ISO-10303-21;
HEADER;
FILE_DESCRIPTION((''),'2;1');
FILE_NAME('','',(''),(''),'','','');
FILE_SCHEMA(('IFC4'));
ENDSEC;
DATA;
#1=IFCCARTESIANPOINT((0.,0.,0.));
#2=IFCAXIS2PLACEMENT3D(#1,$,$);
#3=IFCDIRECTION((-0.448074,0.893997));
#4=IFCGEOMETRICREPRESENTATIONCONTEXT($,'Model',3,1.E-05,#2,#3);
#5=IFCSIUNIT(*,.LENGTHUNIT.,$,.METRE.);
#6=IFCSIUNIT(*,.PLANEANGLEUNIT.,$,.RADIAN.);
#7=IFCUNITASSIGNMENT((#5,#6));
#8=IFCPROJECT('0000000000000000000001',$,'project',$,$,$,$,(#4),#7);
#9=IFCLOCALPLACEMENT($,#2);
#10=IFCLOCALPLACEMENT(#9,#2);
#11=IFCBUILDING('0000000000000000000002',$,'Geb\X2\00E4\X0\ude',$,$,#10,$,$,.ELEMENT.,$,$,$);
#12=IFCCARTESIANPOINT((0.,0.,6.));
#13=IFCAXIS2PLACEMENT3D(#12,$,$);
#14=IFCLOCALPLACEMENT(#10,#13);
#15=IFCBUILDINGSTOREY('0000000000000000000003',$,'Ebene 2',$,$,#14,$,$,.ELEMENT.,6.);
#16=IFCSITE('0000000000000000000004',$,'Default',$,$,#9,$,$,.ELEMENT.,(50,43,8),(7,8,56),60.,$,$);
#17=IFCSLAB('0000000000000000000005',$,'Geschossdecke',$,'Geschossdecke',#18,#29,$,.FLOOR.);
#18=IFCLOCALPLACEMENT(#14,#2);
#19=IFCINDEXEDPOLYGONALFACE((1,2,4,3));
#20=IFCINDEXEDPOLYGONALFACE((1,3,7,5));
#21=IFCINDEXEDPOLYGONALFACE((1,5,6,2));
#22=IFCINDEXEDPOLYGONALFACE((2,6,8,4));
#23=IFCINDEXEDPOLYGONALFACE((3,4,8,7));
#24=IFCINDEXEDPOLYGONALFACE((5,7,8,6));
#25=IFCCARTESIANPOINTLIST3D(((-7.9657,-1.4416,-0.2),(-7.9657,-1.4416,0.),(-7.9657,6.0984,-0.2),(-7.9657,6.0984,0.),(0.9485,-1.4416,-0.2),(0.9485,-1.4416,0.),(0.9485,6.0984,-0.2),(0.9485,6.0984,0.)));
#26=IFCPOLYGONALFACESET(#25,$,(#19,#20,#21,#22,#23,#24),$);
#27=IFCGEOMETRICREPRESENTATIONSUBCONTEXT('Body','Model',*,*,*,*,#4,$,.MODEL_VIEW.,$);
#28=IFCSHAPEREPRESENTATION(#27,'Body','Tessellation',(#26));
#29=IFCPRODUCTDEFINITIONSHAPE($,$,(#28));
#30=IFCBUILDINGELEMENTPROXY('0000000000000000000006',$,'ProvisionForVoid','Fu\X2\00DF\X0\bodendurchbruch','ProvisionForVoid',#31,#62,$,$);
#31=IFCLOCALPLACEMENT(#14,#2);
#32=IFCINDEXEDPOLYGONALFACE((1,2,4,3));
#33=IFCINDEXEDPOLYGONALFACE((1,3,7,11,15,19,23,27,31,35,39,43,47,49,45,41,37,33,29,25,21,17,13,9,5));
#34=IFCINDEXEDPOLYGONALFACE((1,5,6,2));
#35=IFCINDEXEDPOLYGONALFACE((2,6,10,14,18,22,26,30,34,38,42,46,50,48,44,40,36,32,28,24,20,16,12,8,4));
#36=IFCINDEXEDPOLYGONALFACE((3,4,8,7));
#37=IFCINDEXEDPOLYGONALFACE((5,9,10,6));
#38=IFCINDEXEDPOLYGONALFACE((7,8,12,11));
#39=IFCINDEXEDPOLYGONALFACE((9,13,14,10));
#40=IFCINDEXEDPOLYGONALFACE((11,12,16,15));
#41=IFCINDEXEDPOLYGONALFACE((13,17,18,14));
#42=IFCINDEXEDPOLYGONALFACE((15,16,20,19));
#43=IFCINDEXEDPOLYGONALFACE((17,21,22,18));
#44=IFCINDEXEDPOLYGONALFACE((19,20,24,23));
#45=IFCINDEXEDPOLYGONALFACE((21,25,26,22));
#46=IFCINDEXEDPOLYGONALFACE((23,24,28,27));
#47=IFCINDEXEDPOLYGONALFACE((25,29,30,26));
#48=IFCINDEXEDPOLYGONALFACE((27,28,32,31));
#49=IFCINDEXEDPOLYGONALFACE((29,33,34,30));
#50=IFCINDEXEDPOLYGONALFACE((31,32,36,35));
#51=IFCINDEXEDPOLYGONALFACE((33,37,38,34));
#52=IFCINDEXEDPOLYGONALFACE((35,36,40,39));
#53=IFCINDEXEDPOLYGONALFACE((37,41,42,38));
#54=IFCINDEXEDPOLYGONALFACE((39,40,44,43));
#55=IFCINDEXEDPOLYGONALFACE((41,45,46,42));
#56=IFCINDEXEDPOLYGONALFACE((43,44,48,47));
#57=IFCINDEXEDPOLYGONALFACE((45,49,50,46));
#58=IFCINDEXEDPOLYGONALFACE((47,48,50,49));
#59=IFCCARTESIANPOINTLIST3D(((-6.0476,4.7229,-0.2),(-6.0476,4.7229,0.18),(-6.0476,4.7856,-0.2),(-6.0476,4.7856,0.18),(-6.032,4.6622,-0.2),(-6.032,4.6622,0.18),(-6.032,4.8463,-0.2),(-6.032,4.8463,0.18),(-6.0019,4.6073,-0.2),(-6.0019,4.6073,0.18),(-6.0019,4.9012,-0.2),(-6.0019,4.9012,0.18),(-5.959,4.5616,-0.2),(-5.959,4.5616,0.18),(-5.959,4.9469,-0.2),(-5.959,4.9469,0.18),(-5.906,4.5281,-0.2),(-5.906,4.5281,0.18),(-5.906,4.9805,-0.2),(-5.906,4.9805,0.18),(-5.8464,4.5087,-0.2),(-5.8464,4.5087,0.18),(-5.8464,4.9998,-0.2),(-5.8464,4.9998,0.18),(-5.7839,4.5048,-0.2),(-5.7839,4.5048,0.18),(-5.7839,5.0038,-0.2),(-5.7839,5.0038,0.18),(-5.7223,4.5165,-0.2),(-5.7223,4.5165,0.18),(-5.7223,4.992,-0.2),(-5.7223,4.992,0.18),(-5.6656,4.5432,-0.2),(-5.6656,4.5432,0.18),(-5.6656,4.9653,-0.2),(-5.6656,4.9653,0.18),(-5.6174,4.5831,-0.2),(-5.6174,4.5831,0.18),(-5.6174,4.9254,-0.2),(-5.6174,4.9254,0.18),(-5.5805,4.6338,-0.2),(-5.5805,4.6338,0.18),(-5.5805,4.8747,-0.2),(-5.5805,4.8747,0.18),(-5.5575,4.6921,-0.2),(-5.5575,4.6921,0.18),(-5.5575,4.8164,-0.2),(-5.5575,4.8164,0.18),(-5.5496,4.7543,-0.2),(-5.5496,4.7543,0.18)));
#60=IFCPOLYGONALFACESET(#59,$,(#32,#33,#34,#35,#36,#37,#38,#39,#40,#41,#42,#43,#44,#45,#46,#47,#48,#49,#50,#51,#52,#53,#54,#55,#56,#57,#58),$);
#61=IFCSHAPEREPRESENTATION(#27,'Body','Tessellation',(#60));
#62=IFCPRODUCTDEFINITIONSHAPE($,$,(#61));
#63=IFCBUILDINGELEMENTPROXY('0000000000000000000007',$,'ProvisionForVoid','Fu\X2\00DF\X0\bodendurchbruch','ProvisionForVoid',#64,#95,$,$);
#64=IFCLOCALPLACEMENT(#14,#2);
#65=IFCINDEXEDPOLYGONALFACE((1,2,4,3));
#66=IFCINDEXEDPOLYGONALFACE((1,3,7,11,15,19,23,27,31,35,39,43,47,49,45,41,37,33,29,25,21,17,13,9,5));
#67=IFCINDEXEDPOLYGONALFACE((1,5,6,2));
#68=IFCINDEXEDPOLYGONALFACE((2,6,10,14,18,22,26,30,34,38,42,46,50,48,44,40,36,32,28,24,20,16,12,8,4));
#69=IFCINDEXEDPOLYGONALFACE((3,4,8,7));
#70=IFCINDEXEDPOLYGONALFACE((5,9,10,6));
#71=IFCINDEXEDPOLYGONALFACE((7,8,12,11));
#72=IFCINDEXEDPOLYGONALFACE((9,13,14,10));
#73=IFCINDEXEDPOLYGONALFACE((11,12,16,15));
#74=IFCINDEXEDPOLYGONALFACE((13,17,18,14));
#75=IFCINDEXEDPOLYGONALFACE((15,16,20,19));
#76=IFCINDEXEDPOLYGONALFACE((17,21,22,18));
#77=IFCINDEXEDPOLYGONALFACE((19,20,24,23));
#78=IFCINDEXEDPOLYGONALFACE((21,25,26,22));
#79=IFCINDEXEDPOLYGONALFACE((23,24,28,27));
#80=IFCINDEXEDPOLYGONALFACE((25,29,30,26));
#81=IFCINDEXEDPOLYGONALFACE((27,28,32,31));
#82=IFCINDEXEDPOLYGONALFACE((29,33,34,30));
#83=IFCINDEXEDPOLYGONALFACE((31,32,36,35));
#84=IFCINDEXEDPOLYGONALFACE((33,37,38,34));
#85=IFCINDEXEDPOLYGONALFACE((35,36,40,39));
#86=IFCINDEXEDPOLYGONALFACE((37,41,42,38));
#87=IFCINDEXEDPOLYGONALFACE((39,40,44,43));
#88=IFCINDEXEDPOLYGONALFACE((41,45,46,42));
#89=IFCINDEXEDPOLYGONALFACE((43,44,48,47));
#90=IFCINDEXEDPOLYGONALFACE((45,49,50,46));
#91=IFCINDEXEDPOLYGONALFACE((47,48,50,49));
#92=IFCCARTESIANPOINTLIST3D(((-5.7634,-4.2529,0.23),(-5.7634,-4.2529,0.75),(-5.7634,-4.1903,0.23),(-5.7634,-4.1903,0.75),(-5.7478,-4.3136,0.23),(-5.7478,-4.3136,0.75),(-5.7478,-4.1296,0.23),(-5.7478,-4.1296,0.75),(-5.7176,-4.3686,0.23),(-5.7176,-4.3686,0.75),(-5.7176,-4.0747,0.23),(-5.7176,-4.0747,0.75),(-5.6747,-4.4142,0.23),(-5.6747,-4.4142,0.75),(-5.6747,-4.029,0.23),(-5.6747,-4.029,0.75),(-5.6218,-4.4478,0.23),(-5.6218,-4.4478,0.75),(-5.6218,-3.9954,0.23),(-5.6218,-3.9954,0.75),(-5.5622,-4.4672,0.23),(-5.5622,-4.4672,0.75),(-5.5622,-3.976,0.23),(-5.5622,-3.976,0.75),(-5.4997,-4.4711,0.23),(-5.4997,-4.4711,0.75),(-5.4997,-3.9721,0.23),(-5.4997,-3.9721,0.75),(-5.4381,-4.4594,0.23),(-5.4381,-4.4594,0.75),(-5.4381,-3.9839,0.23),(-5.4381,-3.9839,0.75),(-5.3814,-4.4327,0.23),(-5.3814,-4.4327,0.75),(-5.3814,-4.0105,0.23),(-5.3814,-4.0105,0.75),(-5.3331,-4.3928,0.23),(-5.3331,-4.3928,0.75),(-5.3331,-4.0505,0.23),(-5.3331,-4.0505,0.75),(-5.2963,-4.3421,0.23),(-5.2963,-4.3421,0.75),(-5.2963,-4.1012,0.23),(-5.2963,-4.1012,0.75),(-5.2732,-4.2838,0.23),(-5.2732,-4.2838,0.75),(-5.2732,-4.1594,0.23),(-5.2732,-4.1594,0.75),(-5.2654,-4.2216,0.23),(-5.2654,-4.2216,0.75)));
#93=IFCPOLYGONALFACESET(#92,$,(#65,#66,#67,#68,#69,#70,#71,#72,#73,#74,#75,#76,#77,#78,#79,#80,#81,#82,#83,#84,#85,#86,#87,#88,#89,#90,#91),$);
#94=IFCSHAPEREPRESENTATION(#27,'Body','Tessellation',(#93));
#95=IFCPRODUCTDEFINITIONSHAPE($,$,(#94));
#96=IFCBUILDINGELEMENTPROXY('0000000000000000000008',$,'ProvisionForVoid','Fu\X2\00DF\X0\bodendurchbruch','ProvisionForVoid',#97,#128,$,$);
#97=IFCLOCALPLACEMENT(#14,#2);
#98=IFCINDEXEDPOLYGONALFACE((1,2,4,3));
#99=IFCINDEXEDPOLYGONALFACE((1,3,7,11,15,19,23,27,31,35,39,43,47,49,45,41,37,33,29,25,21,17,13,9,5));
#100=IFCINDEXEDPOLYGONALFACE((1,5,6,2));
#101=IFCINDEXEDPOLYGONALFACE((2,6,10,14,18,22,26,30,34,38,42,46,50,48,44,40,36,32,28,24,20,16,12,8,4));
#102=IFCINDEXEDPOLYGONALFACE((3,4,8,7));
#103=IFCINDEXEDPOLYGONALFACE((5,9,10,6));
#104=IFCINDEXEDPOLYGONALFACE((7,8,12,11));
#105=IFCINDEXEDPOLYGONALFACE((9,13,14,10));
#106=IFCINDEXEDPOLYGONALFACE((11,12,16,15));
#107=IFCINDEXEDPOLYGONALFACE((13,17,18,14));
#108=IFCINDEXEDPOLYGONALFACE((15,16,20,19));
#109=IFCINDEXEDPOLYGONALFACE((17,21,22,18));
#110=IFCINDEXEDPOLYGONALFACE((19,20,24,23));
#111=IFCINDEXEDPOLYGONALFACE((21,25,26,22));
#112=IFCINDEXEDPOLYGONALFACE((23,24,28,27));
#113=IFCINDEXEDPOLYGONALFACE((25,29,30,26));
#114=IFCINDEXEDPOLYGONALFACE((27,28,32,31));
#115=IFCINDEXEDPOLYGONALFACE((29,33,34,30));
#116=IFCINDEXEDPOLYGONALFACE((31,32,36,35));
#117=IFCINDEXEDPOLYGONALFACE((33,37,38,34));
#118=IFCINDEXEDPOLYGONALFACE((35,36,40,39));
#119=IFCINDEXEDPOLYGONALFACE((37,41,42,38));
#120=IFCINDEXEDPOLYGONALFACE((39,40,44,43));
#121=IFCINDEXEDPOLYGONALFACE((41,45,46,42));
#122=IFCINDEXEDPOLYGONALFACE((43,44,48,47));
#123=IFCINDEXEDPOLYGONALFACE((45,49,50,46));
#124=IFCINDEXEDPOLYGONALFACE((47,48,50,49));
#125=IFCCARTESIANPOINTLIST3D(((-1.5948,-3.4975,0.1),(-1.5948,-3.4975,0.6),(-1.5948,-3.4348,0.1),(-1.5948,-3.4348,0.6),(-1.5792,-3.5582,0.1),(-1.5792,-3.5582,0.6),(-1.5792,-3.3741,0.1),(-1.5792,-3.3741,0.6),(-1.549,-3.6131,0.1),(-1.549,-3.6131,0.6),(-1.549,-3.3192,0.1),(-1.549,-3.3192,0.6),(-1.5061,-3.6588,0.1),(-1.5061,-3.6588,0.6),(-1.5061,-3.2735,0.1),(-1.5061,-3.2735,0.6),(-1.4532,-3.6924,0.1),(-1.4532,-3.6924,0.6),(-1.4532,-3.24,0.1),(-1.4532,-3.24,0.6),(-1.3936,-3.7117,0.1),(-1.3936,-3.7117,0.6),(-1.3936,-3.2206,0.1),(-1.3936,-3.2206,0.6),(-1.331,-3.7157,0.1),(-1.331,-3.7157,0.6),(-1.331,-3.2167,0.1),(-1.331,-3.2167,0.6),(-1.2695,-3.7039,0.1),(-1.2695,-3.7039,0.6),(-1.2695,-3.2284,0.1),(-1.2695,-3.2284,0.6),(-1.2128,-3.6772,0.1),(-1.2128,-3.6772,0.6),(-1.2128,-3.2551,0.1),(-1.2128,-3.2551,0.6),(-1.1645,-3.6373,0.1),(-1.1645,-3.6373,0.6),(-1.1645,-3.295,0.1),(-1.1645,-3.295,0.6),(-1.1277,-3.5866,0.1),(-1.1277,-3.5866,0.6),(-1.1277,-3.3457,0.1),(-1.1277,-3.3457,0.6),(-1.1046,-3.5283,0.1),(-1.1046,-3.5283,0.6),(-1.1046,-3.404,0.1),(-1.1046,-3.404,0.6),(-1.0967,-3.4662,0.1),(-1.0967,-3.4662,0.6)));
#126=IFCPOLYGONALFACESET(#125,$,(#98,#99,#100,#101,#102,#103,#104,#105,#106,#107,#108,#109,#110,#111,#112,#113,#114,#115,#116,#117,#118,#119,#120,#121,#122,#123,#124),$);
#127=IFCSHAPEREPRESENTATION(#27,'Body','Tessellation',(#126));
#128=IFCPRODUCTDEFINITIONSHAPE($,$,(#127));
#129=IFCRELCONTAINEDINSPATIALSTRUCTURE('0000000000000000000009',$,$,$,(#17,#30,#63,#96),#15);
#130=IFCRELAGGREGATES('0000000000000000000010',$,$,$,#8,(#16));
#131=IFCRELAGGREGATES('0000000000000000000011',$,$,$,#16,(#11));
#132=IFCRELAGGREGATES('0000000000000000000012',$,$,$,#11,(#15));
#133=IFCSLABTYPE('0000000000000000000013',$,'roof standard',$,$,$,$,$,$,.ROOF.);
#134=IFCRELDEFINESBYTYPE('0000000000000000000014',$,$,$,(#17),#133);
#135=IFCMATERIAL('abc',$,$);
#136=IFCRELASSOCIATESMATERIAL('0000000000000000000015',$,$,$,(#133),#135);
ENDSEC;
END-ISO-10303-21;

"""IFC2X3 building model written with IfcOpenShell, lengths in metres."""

from ifc_helpers import new_model, si_unit, direction, frame, frame_2d, origin, place, context, subcontext, project, spatial, rectangle, circle, extrude, material, type_object, element, save


model = new_model("IFC2X3")

# Units and contexts
model_context = context("Model", 3, precision=1e-05, world=origin(), true_north=direction((-0.448074, 0.893997)))
body_context = subcontext(model_context, "Body", "Model", "MODEL_VIEW")
ifc_project = project(units=[si_unit("LENGTHUNIT", "METRE"), si_unit("PLANEANGLEUNIT", "RADIAN")], contexts=[model_context])

# Site, building, storey
site_placement = place(None, origin())
site = spatial("IfcSite", under=ifc_project, at=site_placement, Name="Default", CompositionType="ELEMENT", RefLatitude=(50, 43, 8), RefLongitude=(7, 8, 56), RefElevation=60.0)
building_placement = place(site_placement, origin())
building = spatial("IfcBuilding", under=site, at=building_placement, Name="Gebäude", CompositionType="ELEMENT")
storey_placement = place(building_placement, frame((0.0, 0.0, 6.0)))
storey = spatial("IfcBuildingStorey", under=building, at=storey_placement, Name="Ebene 2", CompositionType="ELEMENT", Elevation=6.0)

# Slab
ifc_material = material(Name="abc")
slab_type = type_object("IfcSlabType", Name="roof standard", PredefinedType="ROOF", material=ifc_material)
slab_placement = place(storey_placement, origin())
element("IfcSlab", 1, at=slab_placement, inside=storey, type_object=slab_type, Name="Geschossdecke", ObjectType="Geschossdecke", PredefinedType="FLOOR", context=body_context, shape_type="SweptSolid", body=[
    extrude(rectangle(XDim=8.9141, YDim=7.54, at=frame_2d((0.0, 0.0), x_axis=(1.0, 0.0))), frame((-3.5086, 2.3284, -0.2)), (0.0, 0.0, 1.0), 0.2),
])

# Building element proxies
proxy_1_placement = place(storey_placement, origin())
element("IfcBuildingElementProxy", 2, at=proxy_1_placement, inside=storey, Name="ProvisionForVoid", Description="Fußbodendurchbruch", ObjectType="ProvisionForVoid", context=body_context, shape_type="SweptSolid", body=[
    extrude(circle(Radius=0.25, at=frame_2d((0.0, 0.0), x_axis=(1.0, 0.0))), frame((-5.7996, 4.7543, -0.2)), (0.0, 0.0, 1.0), 0.38),
])
proxy_2_placement = place(storey_placement, origin())
element("IfcBuildingElementProxy", 3, at=proxy_2_placement, inside=storey, Name="ProvisionForVoid", Description="Fußbodendurchbruch", ObjectType="ProvisionForVoid", context=body_context, shape_type="SweptSolid", body=[
    extrude(circle(Radius=0.25, at=frame_2d((0.0, 0.0), x_axis=(1.0, 0.0))), frame((-5.5154, -4.2216, 0.23)), (0.0, 0.0, 1.0), 0.52),
])
proxy_3_placement = place(storey_placement, origin())
element("IfcBuildingElementProxy", 4, at=proxy_3_placement, inside=storey, Name="ProvisionForVoid", Description="Fußbodendurchbruch", ObjectType="ProvisionForVoid", context=body_context, shape_type="SweptSolid", body=[
    extrude(circle(Radius=0.25, at=frame_2d((0.0, 0.0), x_axis=(1.0, 0.0))), frame((-1.3467, -3.4662, 0.1)), (0.0, 0.0, 1.0), 0.5),
])

save(model, "model.ifc")
